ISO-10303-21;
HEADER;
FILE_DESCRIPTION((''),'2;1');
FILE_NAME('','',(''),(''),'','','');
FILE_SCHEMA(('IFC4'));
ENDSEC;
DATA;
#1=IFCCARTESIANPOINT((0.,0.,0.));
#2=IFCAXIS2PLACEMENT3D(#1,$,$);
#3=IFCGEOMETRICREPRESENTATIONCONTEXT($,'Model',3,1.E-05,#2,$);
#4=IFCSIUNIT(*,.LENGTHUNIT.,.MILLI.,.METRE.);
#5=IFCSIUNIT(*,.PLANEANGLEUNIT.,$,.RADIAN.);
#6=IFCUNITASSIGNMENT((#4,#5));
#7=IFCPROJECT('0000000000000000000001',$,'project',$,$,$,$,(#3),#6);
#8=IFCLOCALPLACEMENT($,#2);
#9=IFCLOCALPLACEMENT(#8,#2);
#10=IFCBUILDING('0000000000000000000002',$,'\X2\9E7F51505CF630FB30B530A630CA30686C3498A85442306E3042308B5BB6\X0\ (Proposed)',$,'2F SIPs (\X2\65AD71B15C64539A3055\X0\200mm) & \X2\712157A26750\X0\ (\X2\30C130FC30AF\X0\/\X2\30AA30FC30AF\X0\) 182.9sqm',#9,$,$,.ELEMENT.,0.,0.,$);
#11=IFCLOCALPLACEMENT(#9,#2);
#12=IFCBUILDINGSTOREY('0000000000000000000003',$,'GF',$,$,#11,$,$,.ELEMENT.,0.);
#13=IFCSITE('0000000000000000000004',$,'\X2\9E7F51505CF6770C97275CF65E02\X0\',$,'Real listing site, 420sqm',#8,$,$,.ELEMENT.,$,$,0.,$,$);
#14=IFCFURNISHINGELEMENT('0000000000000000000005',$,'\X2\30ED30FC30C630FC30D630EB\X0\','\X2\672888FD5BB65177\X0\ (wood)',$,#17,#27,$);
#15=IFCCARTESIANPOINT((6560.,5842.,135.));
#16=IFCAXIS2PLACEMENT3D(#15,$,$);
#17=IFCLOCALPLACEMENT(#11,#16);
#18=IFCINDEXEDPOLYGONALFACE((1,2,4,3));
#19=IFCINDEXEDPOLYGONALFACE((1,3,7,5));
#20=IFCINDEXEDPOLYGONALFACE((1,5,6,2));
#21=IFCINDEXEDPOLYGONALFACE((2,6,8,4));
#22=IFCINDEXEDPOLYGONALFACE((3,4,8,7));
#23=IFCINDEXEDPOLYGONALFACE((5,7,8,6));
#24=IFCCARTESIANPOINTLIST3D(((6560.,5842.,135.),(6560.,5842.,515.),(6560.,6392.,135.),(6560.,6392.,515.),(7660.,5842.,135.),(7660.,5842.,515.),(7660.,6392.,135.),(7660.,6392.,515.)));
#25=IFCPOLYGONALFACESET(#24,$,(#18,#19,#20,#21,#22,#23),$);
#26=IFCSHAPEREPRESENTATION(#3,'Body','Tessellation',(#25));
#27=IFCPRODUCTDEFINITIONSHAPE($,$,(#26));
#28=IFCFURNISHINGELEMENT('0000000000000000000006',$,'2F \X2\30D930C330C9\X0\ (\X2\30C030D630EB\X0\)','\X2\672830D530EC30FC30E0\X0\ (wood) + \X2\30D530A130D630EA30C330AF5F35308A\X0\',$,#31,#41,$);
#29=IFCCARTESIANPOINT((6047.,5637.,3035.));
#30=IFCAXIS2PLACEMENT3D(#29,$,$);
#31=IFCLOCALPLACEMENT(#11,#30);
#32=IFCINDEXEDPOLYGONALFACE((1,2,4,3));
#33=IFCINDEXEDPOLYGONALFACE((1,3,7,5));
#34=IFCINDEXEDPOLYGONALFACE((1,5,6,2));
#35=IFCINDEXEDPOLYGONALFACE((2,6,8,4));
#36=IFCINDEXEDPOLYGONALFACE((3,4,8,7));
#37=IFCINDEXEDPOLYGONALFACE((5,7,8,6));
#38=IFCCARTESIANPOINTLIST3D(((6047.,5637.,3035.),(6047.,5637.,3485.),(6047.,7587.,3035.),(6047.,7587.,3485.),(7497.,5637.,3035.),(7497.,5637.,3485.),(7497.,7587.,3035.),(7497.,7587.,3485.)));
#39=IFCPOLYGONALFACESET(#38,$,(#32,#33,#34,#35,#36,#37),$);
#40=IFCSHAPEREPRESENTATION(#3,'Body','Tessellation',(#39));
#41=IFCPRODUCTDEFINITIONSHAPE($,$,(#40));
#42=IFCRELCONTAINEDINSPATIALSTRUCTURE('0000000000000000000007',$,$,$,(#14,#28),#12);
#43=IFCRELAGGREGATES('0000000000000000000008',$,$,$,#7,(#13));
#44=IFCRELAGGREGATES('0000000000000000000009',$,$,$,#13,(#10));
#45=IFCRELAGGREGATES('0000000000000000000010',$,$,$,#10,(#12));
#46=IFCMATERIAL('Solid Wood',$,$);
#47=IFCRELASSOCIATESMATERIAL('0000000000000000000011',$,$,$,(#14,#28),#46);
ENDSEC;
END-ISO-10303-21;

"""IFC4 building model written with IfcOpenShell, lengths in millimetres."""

from ifc_helpers import new_model, si_unit, frame, frame_2d, origin, place, context, project, spatial, rectangle, extrude, material, element, save


model = new_model("IFC4")

# Units and contexts
model_context = context("Model", 3, precision=1e-05, world=origin())
ifc_project = project(units=[si_unit("LENGTHUNIT", "METRE", prefix="MILLI"), si_unit("PLANEANGLEUNIT", "RADIAN")], contexts=[model_context])

# Site, building, storey
site_placement = place(None, origin())
site = spatial("IfcSite", under=ifc_project, at=site_placement, Name="鹿児島県霧島市", ObjectType="Real listing site, 420sqm", CompositionType="ELEMENT", RefElevation=0.0)
building_placement = place(site_placement, origin())
building = spatial("IfcBuilding", under=site, at=building_placement, Name="鹿児島・サウナと水風呂のある家 (Proposed)", ObjectType="2F SIPs (断熱層厚さ200mm) & 無垢材 (チーク/オーク) 182.9sqm", CompositionType="ELEMENT", ElevationOfRefHeight=0.0, ElevationOfTerrain=0.0)
storey_placement = place(building_placement, origin())
storey = spatial("IfcBuildingStorey", under=building, at=storey_placement, Name="GF", CompositionType="ELEMENT", Elevation=0.0)

# Shared definitions
ifc_material_1 = material(Name="Solid Wood")

# Furnishing elements
furnishing_1_placement = place(storey_placement, frame((6560.0, 5842.0, 135.0)))
element("IfcFurnishingElement", 1, at=furnishing_1_placement, inside=storey, material=ifc_material_1, Name="ローテーブル", Description="木製家具 (wood)", context=model_context, shape_type="SweptSolid", body=[
    extrude(rectangle(XDim=1100.0, YDim=550.0, at=frame_2d((550.0, 275.0))), frame((6560.0, 5842.0, 135.0)), (0.0, 0.0, 1.0), 380.0),
])
furnishing_2_placement = place(storey_placement, frame((6047.0, 5637.0, 3035.0)))
element("IfcFurnishingElement", 2, at=furnishing_2_placement, inside=storey, material=ifc_material_1, Name="2F ベッド (ダブル)", Description="木フレーム (wood) + ファブリック張り", context=model_context, shape_type="SweptSolid", body=[
    extrude(rectangle(XDim=1450.0, YDim=1950.0, at=frame_2d((725.0, 975.0))), frame((6047.0, 5637.0, 3035.0)), (0.0, 0.0, 1.0), 450.0),
])

save(model, "model.ifc")
